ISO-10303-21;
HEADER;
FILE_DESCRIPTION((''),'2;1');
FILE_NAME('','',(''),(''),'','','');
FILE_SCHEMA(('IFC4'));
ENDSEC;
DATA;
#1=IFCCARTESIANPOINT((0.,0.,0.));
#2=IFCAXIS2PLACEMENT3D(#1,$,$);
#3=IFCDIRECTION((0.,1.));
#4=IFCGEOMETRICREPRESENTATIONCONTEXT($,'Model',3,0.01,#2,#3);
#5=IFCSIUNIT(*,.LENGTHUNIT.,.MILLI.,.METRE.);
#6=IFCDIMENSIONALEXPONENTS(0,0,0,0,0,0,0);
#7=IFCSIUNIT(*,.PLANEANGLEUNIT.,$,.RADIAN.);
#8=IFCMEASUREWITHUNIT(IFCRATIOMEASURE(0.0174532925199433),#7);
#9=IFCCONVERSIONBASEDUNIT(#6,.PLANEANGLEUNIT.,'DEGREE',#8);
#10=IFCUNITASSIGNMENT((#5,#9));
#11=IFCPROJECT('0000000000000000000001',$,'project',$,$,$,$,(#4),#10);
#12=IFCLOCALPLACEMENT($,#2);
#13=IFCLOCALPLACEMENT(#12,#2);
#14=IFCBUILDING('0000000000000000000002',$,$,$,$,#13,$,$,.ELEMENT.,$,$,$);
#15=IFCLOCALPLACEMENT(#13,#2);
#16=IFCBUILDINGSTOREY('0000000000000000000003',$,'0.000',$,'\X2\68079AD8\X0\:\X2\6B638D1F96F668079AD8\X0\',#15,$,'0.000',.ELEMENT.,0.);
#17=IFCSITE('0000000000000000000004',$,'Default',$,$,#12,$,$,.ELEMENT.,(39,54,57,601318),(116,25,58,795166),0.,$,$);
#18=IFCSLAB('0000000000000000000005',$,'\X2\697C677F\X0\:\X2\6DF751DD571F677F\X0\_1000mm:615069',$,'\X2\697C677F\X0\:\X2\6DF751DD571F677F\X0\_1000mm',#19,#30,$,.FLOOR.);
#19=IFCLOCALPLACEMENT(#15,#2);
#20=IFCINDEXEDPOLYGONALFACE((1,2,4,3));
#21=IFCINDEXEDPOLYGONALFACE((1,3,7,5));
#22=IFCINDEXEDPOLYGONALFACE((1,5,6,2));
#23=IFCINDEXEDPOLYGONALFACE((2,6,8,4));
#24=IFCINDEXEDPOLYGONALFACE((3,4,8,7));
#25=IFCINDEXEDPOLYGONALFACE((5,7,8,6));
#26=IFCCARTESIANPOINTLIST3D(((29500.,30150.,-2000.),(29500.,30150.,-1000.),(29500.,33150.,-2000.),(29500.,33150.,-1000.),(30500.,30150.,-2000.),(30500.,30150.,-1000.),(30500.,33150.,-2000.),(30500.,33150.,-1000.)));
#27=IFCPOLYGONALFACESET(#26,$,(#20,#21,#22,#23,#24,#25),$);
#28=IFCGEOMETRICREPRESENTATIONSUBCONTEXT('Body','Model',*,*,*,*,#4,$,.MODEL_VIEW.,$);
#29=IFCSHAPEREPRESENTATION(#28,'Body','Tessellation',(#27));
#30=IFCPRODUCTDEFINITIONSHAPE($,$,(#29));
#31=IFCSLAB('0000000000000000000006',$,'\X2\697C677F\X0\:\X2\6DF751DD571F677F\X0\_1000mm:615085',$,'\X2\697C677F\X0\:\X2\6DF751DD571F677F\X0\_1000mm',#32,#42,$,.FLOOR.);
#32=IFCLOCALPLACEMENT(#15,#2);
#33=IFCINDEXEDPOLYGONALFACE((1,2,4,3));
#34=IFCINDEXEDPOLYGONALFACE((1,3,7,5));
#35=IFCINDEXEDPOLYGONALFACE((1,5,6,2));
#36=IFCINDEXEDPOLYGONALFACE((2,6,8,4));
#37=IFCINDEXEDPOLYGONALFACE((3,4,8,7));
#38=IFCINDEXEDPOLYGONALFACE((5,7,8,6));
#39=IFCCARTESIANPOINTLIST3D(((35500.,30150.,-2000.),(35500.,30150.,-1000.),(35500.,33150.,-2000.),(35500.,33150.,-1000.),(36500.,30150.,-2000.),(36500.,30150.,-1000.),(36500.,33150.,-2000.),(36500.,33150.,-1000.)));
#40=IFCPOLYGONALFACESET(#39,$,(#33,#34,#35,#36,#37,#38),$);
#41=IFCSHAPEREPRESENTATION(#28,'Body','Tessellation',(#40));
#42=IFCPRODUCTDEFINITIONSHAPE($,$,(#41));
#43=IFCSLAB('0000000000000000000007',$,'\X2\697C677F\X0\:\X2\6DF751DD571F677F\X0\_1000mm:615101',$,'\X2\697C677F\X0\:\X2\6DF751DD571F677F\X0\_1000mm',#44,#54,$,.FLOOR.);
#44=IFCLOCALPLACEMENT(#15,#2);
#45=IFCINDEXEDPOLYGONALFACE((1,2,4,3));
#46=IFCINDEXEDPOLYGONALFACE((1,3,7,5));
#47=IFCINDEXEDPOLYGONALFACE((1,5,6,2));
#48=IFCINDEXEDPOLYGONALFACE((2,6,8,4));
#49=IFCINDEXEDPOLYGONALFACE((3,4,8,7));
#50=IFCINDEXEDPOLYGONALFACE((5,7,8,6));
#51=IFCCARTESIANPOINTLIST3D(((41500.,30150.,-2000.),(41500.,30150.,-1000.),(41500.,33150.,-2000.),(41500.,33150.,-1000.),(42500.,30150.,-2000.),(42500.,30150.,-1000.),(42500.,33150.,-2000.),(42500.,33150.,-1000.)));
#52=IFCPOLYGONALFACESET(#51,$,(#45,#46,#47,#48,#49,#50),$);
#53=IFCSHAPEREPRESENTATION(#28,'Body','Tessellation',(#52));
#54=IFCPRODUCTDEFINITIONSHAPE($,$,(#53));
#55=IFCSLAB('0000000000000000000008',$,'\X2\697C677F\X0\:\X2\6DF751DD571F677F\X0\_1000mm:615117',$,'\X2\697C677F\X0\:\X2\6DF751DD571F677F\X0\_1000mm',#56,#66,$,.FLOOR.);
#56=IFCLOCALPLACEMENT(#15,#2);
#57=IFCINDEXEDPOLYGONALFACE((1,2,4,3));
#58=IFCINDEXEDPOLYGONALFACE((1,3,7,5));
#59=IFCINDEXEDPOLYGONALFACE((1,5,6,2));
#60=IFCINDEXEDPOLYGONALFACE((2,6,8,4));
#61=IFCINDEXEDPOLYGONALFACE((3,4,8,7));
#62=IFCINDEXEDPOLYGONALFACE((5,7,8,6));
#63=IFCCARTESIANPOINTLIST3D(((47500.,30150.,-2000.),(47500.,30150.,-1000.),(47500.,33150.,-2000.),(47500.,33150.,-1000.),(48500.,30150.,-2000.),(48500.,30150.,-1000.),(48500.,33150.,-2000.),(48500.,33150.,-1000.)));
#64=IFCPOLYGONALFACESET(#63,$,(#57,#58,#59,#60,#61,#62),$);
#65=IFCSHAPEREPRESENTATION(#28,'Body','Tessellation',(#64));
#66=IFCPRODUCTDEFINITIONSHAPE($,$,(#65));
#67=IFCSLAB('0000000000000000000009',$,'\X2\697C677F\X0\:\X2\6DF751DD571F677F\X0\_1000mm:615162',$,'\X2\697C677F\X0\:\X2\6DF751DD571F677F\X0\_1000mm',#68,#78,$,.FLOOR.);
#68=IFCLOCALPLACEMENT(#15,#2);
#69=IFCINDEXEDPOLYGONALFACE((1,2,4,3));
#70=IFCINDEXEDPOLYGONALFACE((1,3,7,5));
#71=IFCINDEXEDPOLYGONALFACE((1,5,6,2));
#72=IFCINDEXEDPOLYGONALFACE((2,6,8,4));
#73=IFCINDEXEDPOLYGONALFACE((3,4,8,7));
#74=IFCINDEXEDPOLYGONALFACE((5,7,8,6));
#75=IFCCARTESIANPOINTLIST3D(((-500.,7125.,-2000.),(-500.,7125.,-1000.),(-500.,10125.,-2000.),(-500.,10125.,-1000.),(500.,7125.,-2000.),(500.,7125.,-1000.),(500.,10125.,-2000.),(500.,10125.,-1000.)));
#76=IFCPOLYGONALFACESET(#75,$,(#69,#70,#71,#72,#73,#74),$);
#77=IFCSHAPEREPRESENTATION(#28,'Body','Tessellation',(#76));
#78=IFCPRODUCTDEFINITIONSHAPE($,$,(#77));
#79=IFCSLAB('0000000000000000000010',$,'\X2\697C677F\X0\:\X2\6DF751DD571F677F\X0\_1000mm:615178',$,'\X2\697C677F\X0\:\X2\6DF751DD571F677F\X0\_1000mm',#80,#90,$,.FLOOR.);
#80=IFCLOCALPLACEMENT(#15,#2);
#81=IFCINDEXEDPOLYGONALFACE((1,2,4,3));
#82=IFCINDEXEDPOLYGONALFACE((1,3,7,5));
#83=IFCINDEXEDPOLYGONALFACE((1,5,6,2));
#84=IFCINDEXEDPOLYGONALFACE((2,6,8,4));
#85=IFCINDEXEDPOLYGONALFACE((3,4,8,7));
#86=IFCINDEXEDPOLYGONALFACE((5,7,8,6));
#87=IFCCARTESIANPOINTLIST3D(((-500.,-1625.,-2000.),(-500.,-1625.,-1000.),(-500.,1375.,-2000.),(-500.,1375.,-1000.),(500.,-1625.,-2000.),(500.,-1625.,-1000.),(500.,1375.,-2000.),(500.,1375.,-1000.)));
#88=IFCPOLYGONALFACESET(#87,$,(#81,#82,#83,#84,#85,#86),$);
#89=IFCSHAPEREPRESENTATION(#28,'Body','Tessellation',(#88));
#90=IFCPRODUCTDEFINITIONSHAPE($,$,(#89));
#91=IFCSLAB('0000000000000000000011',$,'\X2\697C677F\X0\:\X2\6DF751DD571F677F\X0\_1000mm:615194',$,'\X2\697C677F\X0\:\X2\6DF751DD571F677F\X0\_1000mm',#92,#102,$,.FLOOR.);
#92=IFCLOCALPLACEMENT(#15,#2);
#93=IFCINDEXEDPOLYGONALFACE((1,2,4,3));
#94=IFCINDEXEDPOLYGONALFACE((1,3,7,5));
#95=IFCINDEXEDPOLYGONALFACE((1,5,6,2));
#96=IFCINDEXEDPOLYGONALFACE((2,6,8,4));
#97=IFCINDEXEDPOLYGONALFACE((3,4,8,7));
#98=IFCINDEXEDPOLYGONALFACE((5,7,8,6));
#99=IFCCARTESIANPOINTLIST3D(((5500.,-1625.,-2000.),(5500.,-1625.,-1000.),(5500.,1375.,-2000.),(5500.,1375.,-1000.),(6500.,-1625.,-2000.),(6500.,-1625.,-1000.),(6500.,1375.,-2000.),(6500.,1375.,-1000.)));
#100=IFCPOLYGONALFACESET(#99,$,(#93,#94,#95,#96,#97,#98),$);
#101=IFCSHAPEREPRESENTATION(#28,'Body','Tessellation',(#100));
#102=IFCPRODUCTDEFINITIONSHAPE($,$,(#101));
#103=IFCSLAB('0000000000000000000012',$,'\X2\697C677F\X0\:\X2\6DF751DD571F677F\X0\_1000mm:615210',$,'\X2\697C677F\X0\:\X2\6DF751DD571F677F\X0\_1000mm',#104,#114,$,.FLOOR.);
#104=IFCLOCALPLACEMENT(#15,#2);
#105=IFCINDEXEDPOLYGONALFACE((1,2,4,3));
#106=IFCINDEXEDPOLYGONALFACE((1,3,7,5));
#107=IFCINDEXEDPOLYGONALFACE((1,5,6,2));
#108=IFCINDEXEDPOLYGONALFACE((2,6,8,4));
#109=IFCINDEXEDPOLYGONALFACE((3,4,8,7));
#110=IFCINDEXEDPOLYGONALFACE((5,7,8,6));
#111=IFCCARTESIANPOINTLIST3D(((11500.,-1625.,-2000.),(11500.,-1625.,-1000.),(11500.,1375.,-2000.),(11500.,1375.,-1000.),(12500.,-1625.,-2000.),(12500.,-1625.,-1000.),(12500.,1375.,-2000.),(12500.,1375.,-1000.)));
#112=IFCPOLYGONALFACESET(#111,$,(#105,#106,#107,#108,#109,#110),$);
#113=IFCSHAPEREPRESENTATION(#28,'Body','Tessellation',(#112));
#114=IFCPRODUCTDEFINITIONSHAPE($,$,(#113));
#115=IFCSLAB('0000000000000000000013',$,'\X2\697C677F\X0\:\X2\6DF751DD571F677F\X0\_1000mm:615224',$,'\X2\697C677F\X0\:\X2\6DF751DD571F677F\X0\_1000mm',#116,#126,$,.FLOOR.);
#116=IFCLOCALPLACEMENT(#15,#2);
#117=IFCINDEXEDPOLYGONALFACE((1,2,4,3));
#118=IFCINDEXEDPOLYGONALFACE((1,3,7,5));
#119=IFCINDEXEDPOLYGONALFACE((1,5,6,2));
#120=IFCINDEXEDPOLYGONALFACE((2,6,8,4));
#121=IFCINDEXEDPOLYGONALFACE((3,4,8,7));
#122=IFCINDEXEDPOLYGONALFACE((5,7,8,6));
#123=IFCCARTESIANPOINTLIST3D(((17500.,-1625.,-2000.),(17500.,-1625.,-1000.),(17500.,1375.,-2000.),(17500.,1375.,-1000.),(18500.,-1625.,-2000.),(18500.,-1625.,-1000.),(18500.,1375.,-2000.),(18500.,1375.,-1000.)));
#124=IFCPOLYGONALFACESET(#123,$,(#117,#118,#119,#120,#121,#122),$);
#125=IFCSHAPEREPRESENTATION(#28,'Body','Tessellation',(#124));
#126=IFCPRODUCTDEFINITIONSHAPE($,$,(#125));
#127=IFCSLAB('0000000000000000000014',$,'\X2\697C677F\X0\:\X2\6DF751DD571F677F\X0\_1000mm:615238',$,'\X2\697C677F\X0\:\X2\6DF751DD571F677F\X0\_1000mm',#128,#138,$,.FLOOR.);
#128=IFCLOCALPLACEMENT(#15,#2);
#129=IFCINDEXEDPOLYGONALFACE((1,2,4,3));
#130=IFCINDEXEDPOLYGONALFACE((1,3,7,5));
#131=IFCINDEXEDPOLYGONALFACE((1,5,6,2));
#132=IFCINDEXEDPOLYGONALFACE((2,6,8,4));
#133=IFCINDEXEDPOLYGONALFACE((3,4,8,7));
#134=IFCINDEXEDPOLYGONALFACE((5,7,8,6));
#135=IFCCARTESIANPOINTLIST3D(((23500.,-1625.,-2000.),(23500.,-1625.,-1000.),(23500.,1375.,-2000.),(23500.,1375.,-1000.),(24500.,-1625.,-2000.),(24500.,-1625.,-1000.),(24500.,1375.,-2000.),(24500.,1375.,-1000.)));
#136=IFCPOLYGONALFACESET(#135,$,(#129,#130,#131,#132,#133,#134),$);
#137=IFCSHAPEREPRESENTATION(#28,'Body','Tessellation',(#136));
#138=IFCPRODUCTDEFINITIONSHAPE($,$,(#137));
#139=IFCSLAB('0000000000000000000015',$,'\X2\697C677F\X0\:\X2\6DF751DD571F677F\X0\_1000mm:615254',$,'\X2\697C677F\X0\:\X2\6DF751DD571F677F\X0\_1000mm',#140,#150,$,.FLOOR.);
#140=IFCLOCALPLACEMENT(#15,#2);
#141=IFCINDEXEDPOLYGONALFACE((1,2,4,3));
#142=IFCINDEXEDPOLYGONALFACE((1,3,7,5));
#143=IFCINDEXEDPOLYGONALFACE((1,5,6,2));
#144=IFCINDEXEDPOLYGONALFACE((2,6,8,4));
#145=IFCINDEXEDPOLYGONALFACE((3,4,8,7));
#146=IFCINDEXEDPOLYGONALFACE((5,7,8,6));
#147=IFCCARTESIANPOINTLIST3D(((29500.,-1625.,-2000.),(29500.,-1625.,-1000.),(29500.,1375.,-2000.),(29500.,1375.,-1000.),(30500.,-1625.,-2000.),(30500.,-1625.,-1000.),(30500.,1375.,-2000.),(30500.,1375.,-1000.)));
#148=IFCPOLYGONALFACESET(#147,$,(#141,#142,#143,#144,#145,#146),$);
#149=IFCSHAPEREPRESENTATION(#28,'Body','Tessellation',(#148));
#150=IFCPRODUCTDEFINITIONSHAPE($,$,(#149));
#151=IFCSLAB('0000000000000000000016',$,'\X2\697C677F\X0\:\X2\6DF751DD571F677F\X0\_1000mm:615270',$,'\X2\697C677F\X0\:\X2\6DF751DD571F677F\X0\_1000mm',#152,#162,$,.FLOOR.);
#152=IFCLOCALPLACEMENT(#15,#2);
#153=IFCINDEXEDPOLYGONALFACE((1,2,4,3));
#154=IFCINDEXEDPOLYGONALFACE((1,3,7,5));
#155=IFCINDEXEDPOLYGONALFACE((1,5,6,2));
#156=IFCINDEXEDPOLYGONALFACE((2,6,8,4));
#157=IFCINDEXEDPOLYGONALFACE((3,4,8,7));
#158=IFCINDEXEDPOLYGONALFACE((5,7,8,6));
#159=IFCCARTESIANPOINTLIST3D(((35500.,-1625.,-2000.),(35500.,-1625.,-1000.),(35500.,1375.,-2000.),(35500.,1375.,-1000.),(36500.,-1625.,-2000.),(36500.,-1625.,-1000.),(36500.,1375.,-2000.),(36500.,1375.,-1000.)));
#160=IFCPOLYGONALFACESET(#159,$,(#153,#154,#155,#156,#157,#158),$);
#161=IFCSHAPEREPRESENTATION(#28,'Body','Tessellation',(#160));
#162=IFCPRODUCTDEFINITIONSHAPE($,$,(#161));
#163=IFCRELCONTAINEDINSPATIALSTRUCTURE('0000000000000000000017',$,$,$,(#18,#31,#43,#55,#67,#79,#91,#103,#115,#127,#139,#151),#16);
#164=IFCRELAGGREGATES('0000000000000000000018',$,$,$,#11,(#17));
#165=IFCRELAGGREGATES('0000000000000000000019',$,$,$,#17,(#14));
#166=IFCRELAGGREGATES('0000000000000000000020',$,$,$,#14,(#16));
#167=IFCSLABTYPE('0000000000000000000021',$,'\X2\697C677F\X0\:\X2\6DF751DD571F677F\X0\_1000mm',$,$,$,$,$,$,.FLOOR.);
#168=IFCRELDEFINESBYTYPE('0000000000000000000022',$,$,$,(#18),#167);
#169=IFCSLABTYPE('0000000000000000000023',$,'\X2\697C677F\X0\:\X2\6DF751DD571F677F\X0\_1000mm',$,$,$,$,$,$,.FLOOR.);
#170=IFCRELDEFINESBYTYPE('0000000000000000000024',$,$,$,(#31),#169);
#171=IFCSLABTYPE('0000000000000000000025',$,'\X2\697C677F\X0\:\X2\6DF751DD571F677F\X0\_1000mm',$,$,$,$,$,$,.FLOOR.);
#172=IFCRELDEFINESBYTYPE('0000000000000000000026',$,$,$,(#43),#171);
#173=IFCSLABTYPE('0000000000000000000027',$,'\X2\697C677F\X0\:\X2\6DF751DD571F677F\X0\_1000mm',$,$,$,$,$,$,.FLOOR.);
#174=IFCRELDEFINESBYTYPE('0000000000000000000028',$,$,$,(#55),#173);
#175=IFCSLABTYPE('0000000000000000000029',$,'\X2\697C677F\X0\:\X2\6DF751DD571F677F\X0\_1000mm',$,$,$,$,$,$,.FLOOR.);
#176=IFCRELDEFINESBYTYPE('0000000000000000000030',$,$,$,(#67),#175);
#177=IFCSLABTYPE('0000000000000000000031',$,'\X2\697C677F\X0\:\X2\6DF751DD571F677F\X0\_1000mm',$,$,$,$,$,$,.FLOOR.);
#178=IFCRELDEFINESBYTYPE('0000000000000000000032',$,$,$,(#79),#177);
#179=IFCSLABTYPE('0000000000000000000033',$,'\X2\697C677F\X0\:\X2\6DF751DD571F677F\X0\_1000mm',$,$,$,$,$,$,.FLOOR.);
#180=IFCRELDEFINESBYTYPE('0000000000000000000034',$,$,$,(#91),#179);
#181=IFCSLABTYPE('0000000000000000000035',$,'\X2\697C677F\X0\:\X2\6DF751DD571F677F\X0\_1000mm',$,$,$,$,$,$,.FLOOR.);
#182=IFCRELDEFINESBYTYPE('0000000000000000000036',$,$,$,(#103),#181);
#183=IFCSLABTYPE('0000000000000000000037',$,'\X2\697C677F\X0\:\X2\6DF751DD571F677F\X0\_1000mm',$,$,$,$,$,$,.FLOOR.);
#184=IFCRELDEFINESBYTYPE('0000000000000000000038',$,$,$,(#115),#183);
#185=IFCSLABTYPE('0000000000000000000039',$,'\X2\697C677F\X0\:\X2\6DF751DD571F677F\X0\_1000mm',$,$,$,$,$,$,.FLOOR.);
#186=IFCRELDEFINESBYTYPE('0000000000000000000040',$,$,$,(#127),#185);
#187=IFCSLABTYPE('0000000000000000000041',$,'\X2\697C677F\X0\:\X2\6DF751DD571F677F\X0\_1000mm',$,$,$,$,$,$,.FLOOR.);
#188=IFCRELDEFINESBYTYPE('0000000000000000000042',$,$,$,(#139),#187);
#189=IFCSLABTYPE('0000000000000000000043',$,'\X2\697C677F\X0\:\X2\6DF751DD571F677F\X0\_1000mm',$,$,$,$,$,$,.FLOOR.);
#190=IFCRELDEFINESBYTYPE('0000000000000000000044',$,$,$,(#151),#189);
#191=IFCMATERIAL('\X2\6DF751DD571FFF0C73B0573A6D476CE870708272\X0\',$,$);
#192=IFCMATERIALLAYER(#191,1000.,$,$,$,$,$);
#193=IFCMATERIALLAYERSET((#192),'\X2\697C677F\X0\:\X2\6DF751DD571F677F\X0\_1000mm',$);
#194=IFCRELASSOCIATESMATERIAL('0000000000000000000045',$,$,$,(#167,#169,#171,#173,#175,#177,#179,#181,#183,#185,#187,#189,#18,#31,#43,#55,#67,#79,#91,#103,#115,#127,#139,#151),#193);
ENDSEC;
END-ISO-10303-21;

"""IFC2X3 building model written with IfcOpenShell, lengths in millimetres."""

from ifc_helpers import new_model, entity, si_unit, converted_unit, direction, frame, frame_2d, origin, origin_2d_with_axis, place, context, subcontext, project, spatial, rectangle, extrude, material, layer, layer_set, layer_usage, type_object, element, save


model = new_model("IFC2X3")

# Units and contexts
model_context = context("Model", 3, precision=0.01, world=origin(), true_north=direction((0.0, 1.0)))
body_context = subcontext(model_context, "Body", "Model", "MODEL_VIEW")
ifc_project = project(units=[si_unit("LENGTHUNIT", "METRE", prefix="MILLI"), converted_unit("PLANEANGLEUNIT", "DEGREE", entity("IfcRatioMeasure", 0.0174532925199433), si_unit("PLANEANGLEUNIT", "RADIAN"), dimensions=[0, 0, 0, 0, 0, 0, 0])], contexts=[model_context])

# Site, building, storey
site_placement = place(None, origin())
site = spatial("IfcSite", under=ifc_project, at=site_placement, Name="Default", CompositionType="ELEMENT", RefLatitude=(39, 54, 57, 601318), RefLongitude=(116, 25, 58, 795166), RefElevation=0.0)
building_placement = place(site_placement, origin())
building = spatial("IfcBuilding", under=site, at=building_placement, CompositionType="ELEMENT")
storey_placement = place(building_placement, origin())
storey = spatial("IfcBuildingStorey", under=building, at=storey_placement, Name="0.000", ObjectType="标高:正负零标高", LongName="0.000", CompositionType="ELEMENT", Elevation=0.0)

# Slabs
ifc_material_1 = material(Name="混凝土，现场浇注灰色")
ifc_layer_1 = layer(ifc_material_1, 1000.0)
ifc_layer_set_1 = layer_set([ifc_layer_1], Name="楼板:混凝土板_1000mm")
ifc_layer_usage_1 = layer_usage(ifc_layer_set_1, "AXIS3", "POSITIVE", 0.0)
slab_type_1 = type_object("IfcSlabType", Name="楼板:混凝土板_1000mm", PredefinedType="FLOOR", material=ifc_layer_set_1)
slab_1_placement = place(storey_placement, origin())
element("IfcSlab", 1, at=slab_1_placement, inside=storey, type_object=slab_type_1, material=ifc_layer_usage_1, Name="楼板:混凝土板_1000mm:615069", ObjectType="楼板:混凝土板_1000mm", PredefinedType="FLOOR", context=body_context, shape_type="SweptSolid", body=[
    extrude(rectangle(XDim=3000.0, YDim=1000.0, at=frame_2d((0.0, 0.0), x_axis=(1.0, 0.0))), frame((30000.0, 31650.0, -1000.0), z_axis=(0.0, 0.0, -1.0), x_axis=(0.0, 1.0, 0.0)), (0.0, 0.0, 1.0), 1000.0),
])
ifc_layer_usage_2 = layer_usage(ifc_layer_set_1, "AXIS3", "POSITIVE", 0.0)
slab_type_2 = type_object("IfcSlabType", Name="楼板:混凝土板_1000mm", PredefinedType="FLOOR", material=ifc_layer_set_1)
slab_2_placement = place(storey_placement, origin())
element("IfcSlab", 2, at=slab_2_placement, inside=storey, type_object=slab_type_2, material=ifc_layer_usage_2, Name="楼板:混凝土板_1000mm:615085", ObjectType="楼板:混凝土板_1000mm", PredefinedType="FLOOR", context=body_context, shape_type="SweptSolid", body=[
    extrude(rectangle(XDim=3000.0, YDim=1000.0, at=frame_2d((0.0, 0.0), x_axis=(1.0, 0.0))), frame((36000.0, 31650.0, -1000.0), z_axis=(0.0, 0.0, -1.0), x_axis=(0.0, 1.0, 0.0)), (0.0, 0.0, 1.0), 1000.0),
])
ifc_layer_usage_3 = layer_usage(ifc_layer_set_1, "AXIS3", "POSITIVE", 0.0)
slab_type_3 = type_object("IfcSlabType", Name="楼板:混凝土板_1000mm", PredefinedType="FLOOR", material=ifc_layer_set_1)
slab_3_placement = place(storey_placement, origin())
element("IfcSlab", 3, at=slab_3_placement, inside=storey, type_object=slab_type_3, material=ifc_layer_usage_3, Name="楼板:混凝土板_1000mm:615101", ObjectType="楼板:混凝土板_1000mm", PredefinedType="FLOOR", context=body_context, shape_type="SweptSolid", body=[
    extrude(rectangle(XDim=3000.0, YDim=1000.0, at=frame_2d((0.0, 0.0), x_axis=(1.0, 0.0))), frame((42000.0, 31650.0, -1000.0), z_axis=(0.0, 0.0, -1.0), x_axis=(0.0, 1.0, 0.0)), (0.0, 0.0, 1.0), 1000.0),
])
ifc_layer_usage_4 = layer_usage(ifc_layer_set_1, "AXIS3", "POSITIVE", 0.0)
slab_type_4 = type_object("IfcSlabType", Name="楼板:混凝土板_1000mm", PredefinedType="FLOOR", material=ifc_layer_set_1)
slab_4_placement = place(storey_placement, origin())
element("IfcSlab", 4, at=slab_4_placement, inside=storey, type_object=slab_type_4, material=ifc_layer_usage_4, Name="楼板:混凝土板_1000mm:615117", ObjectType="楼板:混凝土板_1000mm", PredefinedType="FLOOR", context=body_context, shape_type="SweptSolid", body=[
    extrude(rectangle(XDim=3000.0, YDim=1000.0, at=frame_2d((0.0, 0.0), x_axis=(1.0, 0.0))), frame((48000.0, 31650.0, -1000.0), z_axis=(0.0, 0.0, -1.0), x_axis=(0.0, 1.0, 0.0)), (0.0, 0.0, 1.0), 1000.0),
])
ifc_layer_usage_5 = layer_usage(ifc_layer_set_1, "AXIS3", "POSITIVE", 0.0)
slab_type_5 = type_object("IfcSlabType", Name="楼板:混凝土板_1000mm", PredefinedType="FLOOR", material=ifc_layer_set_1)
slab_5_placement = place(storey_placement, origin())
element("IfcSlab", 5, at=slab_5_placement, inside=storey, type_object=slab_type_5, material=ifc_layer_usage_5, Name="楼板:混凝土板_1000mm:615162", ObjectType="楼板:混凝土板_1000mm", PredefinedType="FLOOR", context=body_context, shape_type="SweptSolid", body=[
    extrude(rectangle(XDim=3000.0, YDim=1000.0, at=origin_2d_with_axis()), frame((0.0, 8625.0, -1000.0), z_axis=(0.0, 0.0, -1.0), x_axis=(0.0, 1.0, 0.0)), (0.0, 0.0, 1.0), 1000.0),
])
ifc_layer_usage_6 = layer_usage(ifc_layer_set_1, "AXIS3", "POSITIVE", 0.0)
slab_type_6 = type_object("IfcSlabType", Name="楼板:混凝土板_1000mm", PredefinedType="FLOOR", material=ifc_layer_set_1)
slab_6_placement = place(storey_placement, origin())
element("IfcSlab", 6, at=slab_6_placement, inside=storey, type_object=slab_type_6, material=ifc_layer_usage_6, Name="楼板:混凝土板_1000mm:615178", ObjectType="楼板:混凝土板_1000mm", PredefinedType="FLOOR", context=body_context, shape_type="SweptSolid", body=[
    extrude(rectangle(XDim=3000.0, YDim=1000.0, at=origin_2d_with_axis()), frame((0.0, -125.0, -1000.0), z_axis=(0.0, 0.0, -1.0), x_axis=(0.0, 1.0, 0.0)), (0.0, 0.0, 1.0), 1000.0),
])
ifc_layer_usage_7 = layer_usage(ifc_layer_set_1, "AXIS3", "POSITIVE", 0.0)
slab_type_7 = type_object("IfcSlabType", Name="楼板:混凝土板_1000mm", PredefinedType="FLOOR", material=ifc_layer_set_1)
slab_7_placement = place(storey_placement, origin())
element("IfcSlab", 7, at=slab_7_placement, inside=storey, type_object=slab_type_7, material=ifc_layer_usage_7, Name="楼板:混凝土板_1000mm:615194", ObjectType="楼板:混凝土板_1000mm", PredefinedType="FLOOR", context=body_context, shape_type="SweptSolid", body=[
    extrude(rectangle(XDim=3000.0, YDim=1000.0, at=origin_2d_with_axis()), frame((6000.0, -125.0, -1000.0), z_axis=(0.0, 0.0, -1.0), x_axis=(0.0, 1.0, 0.0)), (0.0, 0.0, 1.0), 1000.0),
])
ifc_layer_usage_8 = layer_usage(ifc_layer_set_1, "AXIS3", "POSITIVE", 0.0)
slab_type_8 = type_object("IfcSlabType", Name="楼板:混凝土板_1000mm", PredefinedType="FLOOR", material=ifc_layer_set_1)
slab_8_placement = place(storey_placement, origin())
element("IfcSlab", 8, at=slab_8_placement, inside=storey, type_object=slab_type_8, material=ifc_layer_usage_8, Name="楼板:混凝土板_1000mm:615210", ObjectType="楼板:混凝土板_1000mm", PredefinedType="FLOOR", context=body_context, shape_type="SweptSolid", body=[
    extrude(rectangle(XDim=3000.0, YDim=1000.0, at=frame_2d((0.0, 0.0), x_axis=(1.0, 0.0))), frame((12000.0, -125.0, -1000.0), z_axis=(0.0, 0.0, -1.0), x_axis=(0.0, 1.0, 0.0)), (0.0, 0.0, 1.0), 1000.0),
])
ifc_layer_usage_9 = layer_usage(ifc_layer_set_1, "AXIS3", "POSITIVE", 0.0)
slab_type_9 = type_object("IfcSlabType", Name="楼板:混凝土板_1000mm", PredefinedType="FLOOR", material=ifc_layer_set_1)
slab_9_placement = place(storey_placement, origin())
element("IfcSlab", 9, at=slab_9_placement, inside=storey, type_object=slab_type_9, material=ifc_layer_usage_9, Name="楼板:混凝土板_1000mm:615224", ObjectType="楼板:混凝土板_1000mm", PredefinedType="FLOOR", context=body_context, shape_type="SweptSolid", body=[
    extrude(rectangle(XDim=3000.0, YDim=1000.0, at=frame_2d((0.0, 0.0), x_axis=(1.0, 0.0))), frame((18000.0, -125.0, -1000.0), z_axis=(0.0, 0.0, -1.0), x_axis=(0.0, 1.0, 0.0)), (0.0, 0.0, 1.0), 1000.0),
])
ifc_layer_usage_10 = layer_usage(ifc_layer_set_1, "AXIS3", "POSITIVE", 0.0)
slab_type_10 = type_object("IfcSlabType", Name="楼板:混凝土板_1000mm", PredefinedType="FLOOR", material=ifc_layer_set_1)
slab_10_placement = place(storey_placement, origin())
element("IfcSlab", 10, at=slab_10_placement, inside=storey, type_object=slab_type_10, material=ifc_layer_usage_10, Name="楼板:混凝土板_1000mm:615238", ObjectType="楼板:混凝土板_1000mm", PredefinedType="FLOOR", context=body_context, shape_type="SweptSolid", body=[
    extrude(rectangle(XDim=3000.0, YDim=1000.0, at=origin_2d_with_axis()), frame((24000.0, -125.0, -1000.0), z_axis=(0.0, 0.0, -1.0), x_axis=(0.0, 1.0, 0.0)), (0.0, 0.0, 1.0), 1000.0),
])
ifc_layer_usage_11 = layer_usage(ifc_layer_set_1, "AXIS3", "POSITIVE", 0.0)
slab_type_11 = type_object("IfcSlabType", Name="楼板:混凝土板_1000mm", PredefinedType="FLOOR", material=ifc_layer_set_1)
slab_11_placement = place(storey_placement, origin())
element("IfcSlab", 11, at=slab_11_placement, inside=storey, type_object=slab_type_11, material=ifc_layer_usage_11, Name="楼板:混凝土板_1000mm:615254", ObjectType="楼板:混凝土板_1000mm", PredefinedType="FLOOR", context=body_context, shape_type="SweptSolid", body=[
    extrude(rectangle(XDim=3000.0, YDim=1000.0, at=origin_2d_with_axis()), frame((30000.0, -125.0, -1000.0), z_axis=(0.0, 0.0, -1.0), x_axis=(0.0, 1.0, 0.0)), (0.0, 0.0, 1.0), 1000.0),
])
ifc_layer_usage_12 = layer_usage(ifc_layer_set_1, "AXIS3", "POSITIVE", 0.0)
slab_type_12 = type_object("IfcSlabType", Name="楼板:混凝土板_1000mm", PredefinedType="FLOOR", material=ifc_layer_set_1)
slab_12_placement = place(storey_placement, origin())
element("IfcSlab", 12, at=slab_12_placement, inside=storey, type_object=slab_type_12, material=ifc_layer_usage_12, Name="楼板:混凝土板_1000mm:615270", ObjectType="楼板:混凝土板_1000mm", PredefinedType="FLOOR", context=body_context, shape_type="SweptSolid", body=[
    extrude(rectangle(XDim=3000.0, YDim=1000.0, at=origin_2d_with_axis()), frame((36000.0, -125.0, -1000.0), z_axis=(0.0, 0.0, -1.0), x_axis=(0.0, 1.0, 0.0)), (0.0, 0.0, 1.0), 1000.0),
])

save(model, "model.ifc")
